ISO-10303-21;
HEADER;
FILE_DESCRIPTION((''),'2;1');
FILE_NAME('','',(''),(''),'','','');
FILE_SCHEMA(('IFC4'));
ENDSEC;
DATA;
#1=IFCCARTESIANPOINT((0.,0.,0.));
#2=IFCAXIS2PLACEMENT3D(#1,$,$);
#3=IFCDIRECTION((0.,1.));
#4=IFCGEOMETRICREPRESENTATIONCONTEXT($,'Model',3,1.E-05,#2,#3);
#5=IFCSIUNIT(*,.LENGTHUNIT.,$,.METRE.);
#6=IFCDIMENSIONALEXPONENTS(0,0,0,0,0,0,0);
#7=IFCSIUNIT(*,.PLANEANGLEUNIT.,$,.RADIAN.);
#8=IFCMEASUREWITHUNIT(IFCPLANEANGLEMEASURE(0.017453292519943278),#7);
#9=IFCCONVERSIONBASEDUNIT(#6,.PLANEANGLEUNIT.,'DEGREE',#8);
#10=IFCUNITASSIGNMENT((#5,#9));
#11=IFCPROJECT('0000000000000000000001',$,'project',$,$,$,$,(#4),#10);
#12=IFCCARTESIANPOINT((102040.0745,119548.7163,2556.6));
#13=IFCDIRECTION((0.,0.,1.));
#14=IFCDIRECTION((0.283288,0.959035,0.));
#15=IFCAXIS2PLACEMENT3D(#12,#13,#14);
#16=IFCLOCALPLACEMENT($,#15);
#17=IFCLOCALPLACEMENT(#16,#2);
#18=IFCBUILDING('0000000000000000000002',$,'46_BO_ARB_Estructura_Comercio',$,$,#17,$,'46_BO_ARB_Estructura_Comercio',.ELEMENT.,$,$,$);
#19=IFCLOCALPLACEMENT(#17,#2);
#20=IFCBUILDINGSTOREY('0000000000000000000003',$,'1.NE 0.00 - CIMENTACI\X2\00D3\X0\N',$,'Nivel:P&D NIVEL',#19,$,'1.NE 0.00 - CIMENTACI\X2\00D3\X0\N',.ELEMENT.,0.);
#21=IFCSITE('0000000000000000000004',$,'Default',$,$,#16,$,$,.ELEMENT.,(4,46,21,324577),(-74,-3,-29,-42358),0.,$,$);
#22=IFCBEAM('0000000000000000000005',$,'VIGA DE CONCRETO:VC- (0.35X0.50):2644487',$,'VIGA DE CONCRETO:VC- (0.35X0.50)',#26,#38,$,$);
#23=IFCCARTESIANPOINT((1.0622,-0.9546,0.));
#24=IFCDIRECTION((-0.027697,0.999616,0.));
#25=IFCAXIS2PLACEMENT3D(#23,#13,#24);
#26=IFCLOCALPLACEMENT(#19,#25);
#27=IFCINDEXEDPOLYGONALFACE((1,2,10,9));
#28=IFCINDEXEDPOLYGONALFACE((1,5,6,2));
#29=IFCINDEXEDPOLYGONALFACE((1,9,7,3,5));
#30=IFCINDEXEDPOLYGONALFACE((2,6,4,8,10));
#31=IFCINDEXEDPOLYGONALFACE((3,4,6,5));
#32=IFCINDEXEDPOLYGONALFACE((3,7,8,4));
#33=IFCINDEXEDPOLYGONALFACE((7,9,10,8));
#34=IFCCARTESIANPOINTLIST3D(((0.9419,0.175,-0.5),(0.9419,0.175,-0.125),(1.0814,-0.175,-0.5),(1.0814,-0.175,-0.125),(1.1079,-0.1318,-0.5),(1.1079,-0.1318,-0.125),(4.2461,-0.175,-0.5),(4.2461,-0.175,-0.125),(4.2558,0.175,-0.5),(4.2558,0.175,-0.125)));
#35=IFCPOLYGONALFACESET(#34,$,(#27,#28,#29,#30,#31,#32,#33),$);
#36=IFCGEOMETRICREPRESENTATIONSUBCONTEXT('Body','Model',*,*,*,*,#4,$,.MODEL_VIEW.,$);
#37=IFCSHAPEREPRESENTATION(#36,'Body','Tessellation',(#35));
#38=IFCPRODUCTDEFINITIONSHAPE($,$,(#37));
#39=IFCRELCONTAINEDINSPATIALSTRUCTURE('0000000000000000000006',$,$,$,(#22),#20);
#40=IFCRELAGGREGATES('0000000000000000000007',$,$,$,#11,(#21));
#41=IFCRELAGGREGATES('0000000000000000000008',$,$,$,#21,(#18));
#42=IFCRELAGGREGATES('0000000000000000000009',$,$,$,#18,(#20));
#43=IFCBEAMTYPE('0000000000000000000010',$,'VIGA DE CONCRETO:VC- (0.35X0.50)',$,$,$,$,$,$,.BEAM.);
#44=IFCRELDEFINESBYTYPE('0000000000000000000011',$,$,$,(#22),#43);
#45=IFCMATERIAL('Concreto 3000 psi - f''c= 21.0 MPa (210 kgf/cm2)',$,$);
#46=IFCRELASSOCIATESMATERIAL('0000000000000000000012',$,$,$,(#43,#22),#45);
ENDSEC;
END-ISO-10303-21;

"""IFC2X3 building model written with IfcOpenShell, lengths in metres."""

from ifc_helpers import new_model, entity, si_unit, converted_unit, direction, frame, frame_2d, origin, place, context, subcontext, project, spatial, polyline, rectangle, extrude, clip, halfspace, bounded_halfspace, material, type_object, element, save


model = new_model("IFC2X3")

# Units and contexts
model_context = context("Model", 3, precision=1e-05, world=origin(), true_north=direction((0.0, 1.0)))
body_context = subcontext(model_context, "Body", "Model", "MODEL_VIEW")
ifc_project = project(units=[si_unit("LENGTHUNIT", "METRE"), converted_unit("PLANEANGLEUNIT", "DEGREE", entity("IfcPlaneAngleMeasure", 0.017453292519943278), si_unit("PLANEANGLEUNIT", "RADIAN"), dimensions=[0, 0, 0, 0, 0, 0, 0])], contexts=[model_context])

# Site, building, storey
site_placement = place(None, frame((102040.0745, 119548.7163, 2556.6), z_axis=(0.0, 0.0, 1.0), x_axis=(0.283288, 0.959035, 0.0)))
site = spatial("IfcSite", under=ifc_project, at=site_placement, Name="Default", CompositionType="ELEMENT", RefLatitude=(4, 46, 21, 324577), RefLongitude=(-74, -3, -29, -42358), RefElevation=0.0)
building_placement = place(site_placement, origin())
building = spatial("IfcBuilding", under=site, at=building_placement, Name="46_BO_ARB_Estructura_Comercio", LongName="46_BO_ARB_Estructura_Comercio", CompositionType="ELEMENT")
storey_placement = place(building_placement, origin())
storey = spatial("IfcBuildingStorey", under=building, at=storey_placement, Name="1.NE 0.00 - CIMENTACIÓN", ObjectType="Nivel:P&D NIVEL", LongName="1.NE 0.00 - CIMENTACIÓN", CompositionType="ELEMENT", Elevation=0.0)

# Beam
ifc_material_1 = material(Name="Concreto 3000 psi - f'c= 21.0 MPa (210 kgf/cm2)")
beam_type_1 = type_object("IfcBeamType", Name="VIGA DE CONCRETO:VC- (0.35X0.50)", PredefinedType="BEAM", material=ifc_material_1)
beam_1_placement = place(storey_placement, frame((1.0622, -0.9546, 0.0), z_axis=(0.0, 0.0, 1.0), x_axis=(-0.027697, 0.999616, 0.0)))
element("IfcBeam", 1, at=beam_1_placement, inside=storey, type_object=beam_type_1, material=ifc_material_1, Name="VIGA DE CONCRETO:VC- (0.35X0.50):2644487", ObjectType="VIGA DE CONCRETO:VC- (0.35X0.50)", context=body_context, shape_type="SweptSolid", body=[
    clip(clip(clip(extrude(rectangle(XDim=0.375, YDim=0.35, at=frame_2d((0.0, 0.0), x_axis=(1.0, 0.0))), frame((0.9419, 0.0, -0.3125), z_axis=(1.0, 0.0, 0.0), x_axis=(0.0, 0.0, -1.0)), (0.0, 0.0, 1.0), 3.3138), halfspace(frame((4.2628, 0.431, 0.0), z_axis=(0.999616, -0.027697, 0.0), x_axis=(0.0, 0.0, -1.0)), False)), bounded_halfspace(frame((0.2113, -1.5901, 0.0), z_axis=(-0.851845, 0.523794, 0.0), x_axis=(0.0, 0.0, -1.0)), False, frame((0.9419, 0.0, -0.3125), z_axis=(1.0, 0.0, 0.0), x_axis=(0.0, 0.0, -1.0)), polyline([(0.1875, -0.1318), (0.1875, -0.175), (-0.1875, -0.175), (-0.1875, -0.1318), (0.1875, -0.1318)]))), bounded_halfspace(frame((1.1079, -0.1318, 0.0), z_axis=(-0.879542, -0.475822, 0.0), x_axis=(0.0, 0.0, -1.0)), False, frame((0.9419, 0.0, -0.3125), z_axis=(1.0, 0.0, 0.0), x_axis=(0.0, 0.0, -1.0)), polyline([(0.1875, 0.175), (0.1875, -0.1318), (-0.1875, -0.1318), (-0.1875, 0.175), (0.1875, 0.175)]))),
])

save(model, "model.ifc")
